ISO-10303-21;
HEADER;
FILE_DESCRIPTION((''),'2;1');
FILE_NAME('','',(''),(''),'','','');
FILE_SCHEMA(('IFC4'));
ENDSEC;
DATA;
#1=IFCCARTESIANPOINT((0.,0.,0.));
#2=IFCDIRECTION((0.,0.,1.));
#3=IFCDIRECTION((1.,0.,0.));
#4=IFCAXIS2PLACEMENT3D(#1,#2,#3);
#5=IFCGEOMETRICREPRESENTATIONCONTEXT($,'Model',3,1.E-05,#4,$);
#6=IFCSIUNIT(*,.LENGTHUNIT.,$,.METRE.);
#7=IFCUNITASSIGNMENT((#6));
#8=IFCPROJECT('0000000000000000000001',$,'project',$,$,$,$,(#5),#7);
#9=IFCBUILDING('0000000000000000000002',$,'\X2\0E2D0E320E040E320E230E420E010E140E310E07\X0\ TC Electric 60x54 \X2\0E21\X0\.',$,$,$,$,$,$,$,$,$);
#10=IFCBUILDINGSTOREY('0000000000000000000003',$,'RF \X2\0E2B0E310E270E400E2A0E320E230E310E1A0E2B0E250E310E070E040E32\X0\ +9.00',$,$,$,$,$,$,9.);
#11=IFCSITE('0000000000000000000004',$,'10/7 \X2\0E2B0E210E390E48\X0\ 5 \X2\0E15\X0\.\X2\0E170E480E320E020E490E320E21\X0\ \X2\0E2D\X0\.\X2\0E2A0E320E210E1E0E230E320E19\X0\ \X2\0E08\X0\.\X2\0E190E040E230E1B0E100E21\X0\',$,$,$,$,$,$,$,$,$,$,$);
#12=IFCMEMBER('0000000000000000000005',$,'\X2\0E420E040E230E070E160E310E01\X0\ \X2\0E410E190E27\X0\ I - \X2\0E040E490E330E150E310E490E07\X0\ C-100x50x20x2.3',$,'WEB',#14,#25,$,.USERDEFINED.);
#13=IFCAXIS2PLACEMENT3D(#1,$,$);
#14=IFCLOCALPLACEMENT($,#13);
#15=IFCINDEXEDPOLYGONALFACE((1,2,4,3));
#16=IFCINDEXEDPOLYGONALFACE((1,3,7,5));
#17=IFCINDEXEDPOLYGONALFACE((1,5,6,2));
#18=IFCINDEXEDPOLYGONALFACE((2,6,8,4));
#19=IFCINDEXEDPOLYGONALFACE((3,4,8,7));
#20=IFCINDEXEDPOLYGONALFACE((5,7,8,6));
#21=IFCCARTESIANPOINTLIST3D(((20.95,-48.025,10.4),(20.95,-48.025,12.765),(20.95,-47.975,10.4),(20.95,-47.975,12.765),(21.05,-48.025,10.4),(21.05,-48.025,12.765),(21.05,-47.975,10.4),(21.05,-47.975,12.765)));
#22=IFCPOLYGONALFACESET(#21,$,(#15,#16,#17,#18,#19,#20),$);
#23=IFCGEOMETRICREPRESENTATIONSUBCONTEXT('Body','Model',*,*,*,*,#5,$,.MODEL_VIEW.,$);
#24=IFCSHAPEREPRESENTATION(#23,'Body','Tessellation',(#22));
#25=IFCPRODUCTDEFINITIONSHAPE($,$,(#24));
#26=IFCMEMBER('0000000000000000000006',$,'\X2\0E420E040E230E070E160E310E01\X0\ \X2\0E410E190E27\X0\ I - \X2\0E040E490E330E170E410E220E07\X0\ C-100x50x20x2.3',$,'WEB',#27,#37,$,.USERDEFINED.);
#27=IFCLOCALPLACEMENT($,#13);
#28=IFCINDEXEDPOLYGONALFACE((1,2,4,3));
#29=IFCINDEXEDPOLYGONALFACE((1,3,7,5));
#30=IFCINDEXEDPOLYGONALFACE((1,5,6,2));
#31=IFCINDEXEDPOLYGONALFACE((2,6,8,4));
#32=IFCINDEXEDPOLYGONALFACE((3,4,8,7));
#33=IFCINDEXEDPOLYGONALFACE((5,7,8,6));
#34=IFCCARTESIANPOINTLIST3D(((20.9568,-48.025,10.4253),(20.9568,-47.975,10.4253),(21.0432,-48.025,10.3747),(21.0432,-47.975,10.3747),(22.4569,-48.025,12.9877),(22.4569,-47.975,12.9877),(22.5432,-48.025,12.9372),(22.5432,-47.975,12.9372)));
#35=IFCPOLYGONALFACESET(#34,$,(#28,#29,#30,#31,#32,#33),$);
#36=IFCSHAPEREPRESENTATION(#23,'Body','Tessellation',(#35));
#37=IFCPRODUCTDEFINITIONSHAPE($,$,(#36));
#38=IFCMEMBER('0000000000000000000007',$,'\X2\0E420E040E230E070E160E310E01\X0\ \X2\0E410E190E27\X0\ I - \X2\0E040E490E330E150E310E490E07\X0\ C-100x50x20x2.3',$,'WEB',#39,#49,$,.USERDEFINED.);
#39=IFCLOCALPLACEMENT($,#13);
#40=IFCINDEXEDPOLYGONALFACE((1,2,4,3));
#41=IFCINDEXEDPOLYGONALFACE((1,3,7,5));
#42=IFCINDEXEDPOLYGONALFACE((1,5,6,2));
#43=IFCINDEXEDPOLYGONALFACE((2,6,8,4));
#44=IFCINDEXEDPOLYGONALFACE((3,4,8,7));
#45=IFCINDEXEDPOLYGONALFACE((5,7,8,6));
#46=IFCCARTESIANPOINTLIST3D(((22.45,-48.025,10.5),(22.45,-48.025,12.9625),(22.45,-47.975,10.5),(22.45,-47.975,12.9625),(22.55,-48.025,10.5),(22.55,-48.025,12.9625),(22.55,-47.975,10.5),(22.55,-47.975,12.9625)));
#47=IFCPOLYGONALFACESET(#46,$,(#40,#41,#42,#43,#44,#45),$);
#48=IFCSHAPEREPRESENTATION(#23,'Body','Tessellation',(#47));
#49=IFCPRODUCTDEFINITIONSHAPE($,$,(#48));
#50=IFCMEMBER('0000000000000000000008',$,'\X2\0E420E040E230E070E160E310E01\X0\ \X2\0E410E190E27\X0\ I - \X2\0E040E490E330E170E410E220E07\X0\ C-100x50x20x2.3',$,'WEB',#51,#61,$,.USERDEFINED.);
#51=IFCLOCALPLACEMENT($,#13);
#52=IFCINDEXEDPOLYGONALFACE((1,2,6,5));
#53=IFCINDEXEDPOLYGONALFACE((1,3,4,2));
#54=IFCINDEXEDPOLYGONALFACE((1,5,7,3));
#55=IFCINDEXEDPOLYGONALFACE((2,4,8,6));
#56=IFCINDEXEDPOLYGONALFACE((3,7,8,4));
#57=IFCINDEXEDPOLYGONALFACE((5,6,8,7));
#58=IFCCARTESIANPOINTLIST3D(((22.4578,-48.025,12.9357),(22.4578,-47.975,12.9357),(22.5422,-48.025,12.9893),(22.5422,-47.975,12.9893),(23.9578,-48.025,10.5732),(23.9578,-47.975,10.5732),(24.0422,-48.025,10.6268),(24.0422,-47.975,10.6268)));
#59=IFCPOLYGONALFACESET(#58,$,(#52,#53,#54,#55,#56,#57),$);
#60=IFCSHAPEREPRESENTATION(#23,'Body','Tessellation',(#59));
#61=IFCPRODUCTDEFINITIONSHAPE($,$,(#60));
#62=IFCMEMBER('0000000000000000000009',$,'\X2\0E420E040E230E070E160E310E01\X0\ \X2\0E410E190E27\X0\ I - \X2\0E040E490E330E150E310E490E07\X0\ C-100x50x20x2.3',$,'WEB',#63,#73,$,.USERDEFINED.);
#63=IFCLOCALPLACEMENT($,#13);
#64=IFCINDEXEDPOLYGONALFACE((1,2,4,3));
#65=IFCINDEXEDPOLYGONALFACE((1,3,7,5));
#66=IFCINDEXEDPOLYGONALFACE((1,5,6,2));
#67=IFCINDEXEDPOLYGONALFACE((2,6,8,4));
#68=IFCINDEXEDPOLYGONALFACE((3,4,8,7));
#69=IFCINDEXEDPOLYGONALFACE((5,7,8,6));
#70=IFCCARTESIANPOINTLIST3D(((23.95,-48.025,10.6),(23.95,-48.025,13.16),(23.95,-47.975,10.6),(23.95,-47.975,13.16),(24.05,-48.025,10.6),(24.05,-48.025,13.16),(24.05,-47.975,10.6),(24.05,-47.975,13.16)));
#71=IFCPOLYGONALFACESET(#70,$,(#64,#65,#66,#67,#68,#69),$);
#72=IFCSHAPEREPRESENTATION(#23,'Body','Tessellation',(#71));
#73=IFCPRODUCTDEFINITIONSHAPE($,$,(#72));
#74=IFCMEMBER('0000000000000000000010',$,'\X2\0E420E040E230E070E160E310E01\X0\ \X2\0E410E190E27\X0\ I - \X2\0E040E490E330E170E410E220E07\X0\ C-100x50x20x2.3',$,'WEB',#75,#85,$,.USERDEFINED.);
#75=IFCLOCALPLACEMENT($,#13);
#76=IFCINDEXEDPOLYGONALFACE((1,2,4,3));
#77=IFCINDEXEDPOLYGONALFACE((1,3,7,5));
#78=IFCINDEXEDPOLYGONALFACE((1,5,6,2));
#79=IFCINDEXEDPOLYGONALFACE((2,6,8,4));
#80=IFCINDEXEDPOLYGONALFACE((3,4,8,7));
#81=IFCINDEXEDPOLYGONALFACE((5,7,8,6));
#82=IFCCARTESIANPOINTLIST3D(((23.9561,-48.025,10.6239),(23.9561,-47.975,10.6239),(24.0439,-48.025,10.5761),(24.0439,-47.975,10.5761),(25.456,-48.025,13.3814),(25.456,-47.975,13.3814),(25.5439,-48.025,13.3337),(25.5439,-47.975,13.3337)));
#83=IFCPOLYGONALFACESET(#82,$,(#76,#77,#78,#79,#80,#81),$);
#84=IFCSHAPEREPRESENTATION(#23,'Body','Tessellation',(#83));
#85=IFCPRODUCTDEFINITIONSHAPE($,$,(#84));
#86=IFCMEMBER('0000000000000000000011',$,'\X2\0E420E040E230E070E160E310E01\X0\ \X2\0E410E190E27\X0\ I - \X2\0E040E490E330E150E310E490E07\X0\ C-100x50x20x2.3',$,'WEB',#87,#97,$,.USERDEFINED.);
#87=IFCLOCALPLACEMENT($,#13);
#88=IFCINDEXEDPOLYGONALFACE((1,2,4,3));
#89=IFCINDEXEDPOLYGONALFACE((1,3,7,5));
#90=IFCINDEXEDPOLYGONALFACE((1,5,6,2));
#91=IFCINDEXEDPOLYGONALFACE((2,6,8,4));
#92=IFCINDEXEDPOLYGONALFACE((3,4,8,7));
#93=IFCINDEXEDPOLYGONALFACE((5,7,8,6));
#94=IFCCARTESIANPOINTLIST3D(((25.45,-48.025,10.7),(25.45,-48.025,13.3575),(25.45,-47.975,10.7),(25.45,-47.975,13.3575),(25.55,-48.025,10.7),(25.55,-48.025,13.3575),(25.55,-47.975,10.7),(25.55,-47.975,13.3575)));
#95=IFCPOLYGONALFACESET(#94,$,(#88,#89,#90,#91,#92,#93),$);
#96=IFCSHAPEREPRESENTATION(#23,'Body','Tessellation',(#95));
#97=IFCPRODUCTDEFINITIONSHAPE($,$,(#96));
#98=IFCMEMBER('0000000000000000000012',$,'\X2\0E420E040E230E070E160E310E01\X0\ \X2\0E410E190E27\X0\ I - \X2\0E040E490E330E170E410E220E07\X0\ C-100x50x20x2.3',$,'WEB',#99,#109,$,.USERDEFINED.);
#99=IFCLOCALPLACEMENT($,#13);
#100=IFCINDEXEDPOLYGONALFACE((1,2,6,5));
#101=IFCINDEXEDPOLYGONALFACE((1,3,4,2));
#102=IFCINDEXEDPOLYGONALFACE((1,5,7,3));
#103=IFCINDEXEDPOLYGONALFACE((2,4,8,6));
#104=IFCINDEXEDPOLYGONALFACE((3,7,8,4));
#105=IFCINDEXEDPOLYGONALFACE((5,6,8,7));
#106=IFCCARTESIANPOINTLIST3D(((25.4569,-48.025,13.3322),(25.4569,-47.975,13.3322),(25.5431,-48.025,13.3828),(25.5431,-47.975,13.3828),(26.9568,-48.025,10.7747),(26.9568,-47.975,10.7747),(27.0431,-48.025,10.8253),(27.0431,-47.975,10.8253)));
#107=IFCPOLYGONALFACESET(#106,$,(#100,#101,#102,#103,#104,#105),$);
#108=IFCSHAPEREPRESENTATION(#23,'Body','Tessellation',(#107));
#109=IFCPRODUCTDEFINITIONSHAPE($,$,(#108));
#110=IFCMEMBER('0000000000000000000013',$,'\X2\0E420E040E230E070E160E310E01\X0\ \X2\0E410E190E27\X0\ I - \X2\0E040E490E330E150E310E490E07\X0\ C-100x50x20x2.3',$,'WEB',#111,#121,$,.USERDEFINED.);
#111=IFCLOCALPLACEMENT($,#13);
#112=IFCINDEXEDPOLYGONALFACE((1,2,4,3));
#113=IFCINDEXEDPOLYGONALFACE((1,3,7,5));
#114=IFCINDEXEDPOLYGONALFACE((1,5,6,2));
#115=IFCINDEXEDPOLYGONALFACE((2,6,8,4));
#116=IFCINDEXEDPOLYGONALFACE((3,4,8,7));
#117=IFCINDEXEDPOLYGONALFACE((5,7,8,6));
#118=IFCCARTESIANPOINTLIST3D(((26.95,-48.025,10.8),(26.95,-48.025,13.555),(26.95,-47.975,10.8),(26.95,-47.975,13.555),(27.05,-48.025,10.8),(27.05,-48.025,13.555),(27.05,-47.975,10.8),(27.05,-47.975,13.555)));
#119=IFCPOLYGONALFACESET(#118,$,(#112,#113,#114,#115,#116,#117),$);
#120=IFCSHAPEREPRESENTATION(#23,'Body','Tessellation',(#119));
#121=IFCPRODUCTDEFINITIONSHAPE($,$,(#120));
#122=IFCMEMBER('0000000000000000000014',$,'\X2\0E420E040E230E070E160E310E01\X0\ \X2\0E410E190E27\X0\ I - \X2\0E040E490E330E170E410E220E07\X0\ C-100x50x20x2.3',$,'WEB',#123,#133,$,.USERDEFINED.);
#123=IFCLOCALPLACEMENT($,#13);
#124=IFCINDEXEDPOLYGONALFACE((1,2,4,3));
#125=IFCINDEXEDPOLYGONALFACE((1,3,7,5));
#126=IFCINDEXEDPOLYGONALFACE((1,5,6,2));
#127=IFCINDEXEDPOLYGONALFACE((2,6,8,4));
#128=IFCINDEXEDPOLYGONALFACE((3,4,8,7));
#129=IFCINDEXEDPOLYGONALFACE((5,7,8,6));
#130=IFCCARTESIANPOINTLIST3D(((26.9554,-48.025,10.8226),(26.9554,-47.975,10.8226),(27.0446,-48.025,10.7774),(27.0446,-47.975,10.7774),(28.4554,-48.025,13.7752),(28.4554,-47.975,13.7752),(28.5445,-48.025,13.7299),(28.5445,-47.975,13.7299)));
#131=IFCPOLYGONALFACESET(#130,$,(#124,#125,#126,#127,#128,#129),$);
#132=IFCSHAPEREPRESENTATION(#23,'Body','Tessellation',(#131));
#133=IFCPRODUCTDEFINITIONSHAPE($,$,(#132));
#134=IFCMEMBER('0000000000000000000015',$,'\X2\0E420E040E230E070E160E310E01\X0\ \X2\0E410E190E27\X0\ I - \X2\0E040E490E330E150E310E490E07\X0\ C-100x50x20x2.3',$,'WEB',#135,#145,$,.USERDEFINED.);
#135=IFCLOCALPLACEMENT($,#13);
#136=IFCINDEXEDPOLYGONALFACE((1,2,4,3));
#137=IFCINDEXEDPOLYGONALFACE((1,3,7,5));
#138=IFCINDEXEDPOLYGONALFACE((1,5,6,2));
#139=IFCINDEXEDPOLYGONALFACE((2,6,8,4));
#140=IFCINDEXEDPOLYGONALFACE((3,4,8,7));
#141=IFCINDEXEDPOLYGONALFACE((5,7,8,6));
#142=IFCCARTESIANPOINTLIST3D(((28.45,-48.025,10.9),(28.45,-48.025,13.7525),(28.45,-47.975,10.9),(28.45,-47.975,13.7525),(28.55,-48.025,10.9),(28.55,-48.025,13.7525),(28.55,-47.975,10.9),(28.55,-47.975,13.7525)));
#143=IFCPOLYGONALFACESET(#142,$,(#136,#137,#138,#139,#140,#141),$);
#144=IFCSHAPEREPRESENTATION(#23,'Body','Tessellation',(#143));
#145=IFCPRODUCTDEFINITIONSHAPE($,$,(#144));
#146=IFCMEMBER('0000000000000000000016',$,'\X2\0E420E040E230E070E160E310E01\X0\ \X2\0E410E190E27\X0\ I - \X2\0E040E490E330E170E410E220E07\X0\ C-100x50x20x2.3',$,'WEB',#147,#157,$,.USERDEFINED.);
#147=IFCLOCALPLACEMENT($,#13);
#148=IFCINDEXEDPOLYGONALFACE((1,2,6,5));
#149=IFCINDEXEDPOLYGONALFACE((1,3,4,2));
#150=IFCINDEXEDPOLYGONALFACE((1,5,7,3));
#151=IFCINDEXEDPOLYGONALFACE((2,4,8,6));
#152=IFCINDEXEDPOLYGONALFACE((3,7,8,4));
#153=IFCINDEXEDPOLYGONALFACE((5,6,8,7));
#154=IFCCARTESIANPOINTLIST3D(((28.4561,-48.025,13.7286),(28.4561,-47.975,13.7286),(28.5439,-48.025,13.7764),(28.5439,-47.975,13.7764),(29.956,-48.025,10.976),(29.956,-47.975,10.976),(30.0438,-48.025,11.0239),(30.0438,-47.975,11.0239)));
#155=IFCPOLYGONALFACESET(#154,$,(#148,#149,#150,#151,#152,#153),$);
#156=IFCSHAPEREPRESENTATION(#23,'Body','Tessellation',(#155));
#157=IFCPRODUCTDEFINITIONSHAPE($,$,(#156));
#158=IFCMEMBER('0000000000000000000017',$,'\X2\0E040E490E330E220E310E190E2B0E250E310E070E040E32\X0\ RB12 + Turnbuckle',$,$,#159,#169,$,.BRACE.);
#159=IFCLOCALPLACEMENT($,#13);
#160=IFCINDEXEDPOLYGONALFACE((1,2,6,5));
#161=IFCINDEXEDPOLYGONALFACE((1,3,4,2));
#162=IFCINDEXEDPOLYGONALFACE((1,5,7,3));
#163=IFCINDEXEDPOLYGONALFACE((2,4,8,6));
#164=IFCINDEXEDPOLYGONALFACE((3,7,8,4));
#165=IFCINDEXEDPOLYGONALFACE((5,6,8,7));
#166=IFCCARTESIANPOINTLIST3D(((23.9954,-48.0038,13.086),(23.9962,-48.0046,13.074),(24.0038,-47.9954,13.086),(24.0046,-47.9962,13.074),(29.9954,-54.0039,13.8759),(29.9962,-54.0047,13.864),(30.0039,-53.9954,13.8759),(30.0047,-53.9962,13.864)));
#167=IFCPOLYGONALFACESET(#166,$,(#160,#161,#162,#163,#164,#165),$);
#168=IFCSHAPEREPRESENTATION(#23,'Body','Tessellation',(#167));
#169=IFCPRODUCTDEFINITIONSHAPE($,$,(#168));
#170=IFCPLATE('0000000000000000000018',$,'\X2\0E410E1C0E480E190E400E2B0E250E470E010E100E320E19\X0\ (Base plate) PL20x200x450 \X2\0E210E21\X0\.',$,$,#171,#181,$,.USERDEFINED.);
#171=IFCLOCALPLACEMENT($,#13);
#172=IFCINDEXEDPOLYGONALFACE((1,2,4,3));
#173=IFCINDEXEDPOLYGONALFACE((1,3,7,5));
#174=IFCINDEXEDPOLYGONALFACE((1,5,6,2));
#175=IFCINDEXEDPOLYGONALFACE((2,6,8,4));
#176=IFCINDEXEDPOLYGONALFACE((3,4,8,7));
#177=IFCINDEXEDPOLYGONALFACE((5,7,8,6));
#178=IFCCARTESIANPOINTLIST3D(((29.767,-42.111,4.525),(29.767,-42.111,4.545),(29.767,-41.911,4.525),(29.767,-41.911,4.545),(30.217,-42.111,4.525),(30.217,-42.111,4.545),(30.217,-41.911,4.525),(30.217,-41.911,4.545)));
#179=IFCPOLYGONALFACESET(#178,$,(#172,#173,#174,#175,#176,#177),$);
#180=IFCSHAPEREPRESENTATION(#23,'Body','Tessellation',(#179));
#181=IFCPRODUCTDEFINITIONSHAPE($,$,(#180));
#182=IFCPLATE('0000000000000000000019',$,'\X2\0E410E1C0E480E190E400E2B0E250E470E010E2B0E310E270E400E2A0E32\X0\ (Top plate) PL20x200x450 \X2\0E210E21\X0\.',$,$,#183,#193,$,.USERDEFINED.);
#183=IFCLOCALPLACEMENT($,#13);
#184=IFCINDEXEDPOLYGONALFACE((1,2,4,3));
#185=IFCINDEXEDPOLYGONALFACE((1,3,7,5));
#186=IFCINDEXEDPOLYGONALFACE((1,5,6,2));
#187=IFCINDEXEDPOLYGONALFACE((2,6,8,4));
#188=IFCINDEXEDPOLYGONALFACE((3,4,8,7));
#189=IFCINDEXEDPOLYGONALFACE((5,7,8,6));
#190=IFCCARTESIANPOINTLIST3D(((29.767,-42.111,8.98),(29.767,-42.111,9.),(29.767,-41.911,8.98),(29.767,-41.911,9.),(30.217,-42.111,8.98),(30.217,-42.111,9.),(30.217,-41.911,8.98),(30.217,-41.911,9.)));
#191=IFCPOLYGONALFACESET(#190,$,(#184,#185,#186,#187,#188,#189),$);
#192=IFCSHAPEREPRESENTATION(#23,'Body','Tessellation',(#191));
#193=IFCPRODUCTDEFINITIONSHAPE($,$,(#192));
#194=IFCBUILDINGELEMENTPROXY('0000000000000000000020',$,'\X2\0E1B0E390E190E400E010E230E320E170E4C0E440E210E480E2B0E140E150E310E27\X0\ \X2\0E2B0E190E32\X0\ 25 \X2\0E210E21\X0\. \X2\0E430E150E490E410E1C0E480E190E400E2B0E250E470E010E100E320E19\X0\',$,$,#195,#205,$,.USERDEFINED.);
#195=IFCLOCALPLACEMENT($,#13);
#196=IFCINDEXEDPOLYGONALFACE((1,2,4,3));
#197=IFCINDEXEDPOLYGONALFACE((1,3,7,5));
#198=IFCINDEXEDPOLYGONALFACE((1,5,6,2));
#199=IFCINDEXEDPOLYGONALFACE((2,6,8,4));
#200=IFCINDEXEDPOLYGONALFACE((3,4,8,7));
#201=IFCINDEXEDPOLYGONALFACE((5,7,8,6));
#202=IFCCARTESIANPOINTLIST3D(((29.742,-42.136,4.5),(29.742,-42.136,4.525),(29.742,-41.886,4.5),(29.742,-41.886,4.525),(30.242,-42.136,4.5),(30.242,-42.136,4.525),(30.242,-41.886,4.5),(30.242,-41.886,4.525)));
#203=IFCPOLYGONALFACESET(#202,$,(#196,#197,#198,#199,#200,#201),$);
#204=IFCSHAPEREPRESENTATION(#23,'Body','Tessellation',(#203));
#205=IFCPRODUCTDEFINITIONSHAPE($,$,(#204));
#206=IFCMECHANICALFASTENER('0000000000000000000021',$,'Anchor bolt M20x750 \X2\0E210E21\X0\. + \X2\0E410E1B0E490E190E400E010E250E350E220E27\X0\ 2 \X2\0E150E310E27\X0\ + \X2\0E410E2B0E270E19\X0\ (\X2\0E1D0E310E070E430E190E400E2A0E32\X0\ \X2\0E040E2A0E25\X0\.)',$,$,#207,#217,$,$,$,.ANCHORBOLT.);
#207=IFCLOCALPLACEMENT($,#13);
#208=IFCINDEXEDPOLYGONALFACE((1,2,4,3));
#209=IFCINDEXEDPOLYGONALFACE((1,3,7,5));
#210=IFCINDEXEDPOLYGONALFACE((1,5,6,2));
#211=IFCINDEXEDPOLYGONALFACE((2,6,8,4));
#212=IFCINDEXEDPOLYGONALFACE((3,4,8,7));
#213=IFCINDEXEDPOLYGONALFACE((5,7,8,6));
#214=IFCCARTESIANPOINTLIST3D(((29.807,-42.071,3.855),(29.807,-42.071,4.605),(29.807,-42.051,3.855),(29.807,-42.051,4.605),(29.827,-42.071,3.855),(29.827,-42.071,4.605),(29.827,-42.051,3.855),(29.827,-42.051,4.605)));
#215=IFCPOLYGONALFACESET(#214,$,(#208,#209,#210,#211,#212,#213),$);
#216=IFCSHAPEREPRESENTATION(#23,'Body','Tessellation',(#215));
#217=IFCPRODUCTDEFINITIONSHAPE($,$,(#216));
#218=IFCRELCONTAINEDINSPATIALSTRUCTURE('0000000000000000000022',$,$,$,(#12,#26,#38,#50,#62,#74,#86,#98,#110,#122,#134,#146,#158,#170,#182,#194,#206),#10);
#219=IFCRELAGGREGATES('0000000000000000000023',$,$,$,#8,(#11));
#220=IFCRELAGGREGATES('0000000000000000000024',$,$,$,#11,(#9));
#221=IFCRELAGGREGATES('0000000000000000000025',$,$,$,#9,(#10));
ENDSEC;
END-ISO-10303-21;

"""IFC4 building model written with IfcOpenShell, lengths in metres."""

from ifc_helpers import new_model, si_unit, frame, origin, origin_with_axes, origin_2d, place, context, subcontext, project, spatial, rectangle, extrude, element, save


model = new_model("IFC4")

# Units and contexts
model_context = context("Model", 3, precision=1e-05, world=origin_with_axes())
body_context = subcontext(model_context, "Body", "Model", "MODEL_VIEW")
ifc_project = project(units=[si_unit("LENGTHUNIT", "METRE")], contexts=[model_context])

# Site, building, storey
site = spatial("IfcSite", under=ifc_project, Name="10/7 หมู่ 5 ต.ท่าข้าม อ.สามพราน จ.นครปฐม")
building = spatial("IfcBuilding", under=site, Name="อาคารโกดัง TC Electric 60x54 ม.")
storey = spatial("IfcBuildingStorey", under=building, Name="RF หัวเสารับหลังคา +9.00", Elevation=9.0)

# Members
member_1_placement = place(None, frame((21.0, -48.0, 10.4), z_axis=(0.0, 0.0, 1.0), x_axis=(0.0, 1.0, 0.0)))
element("IfcMember", 1, at=member_1_placement, inside=storey, Name="โครงถัก แนว I - ค้ำตั้ง C-100x50x20x2.3", ObjectType="WEB", PredefinedType="USERDEFINED", context=body_context, shape_type="SweptSolid", body=[
    extrude(rectangle(XDim=0.05, YDim=0.1, at=origin_2d()), origin(), (0.0, 0.0, 1.0), 2.365),
])
member_2_placement = place(None, frame((21.0, -48.0, 10.4), z_axis=(0.5052, 0.0, 0.863), x_axis=(0.0, -1.0, 0.0)))
element("IfcMember", 2, at=member_2_placement, inside=storey, Name="โครงถัก แนว I - ค้ำทแยง C-100x50x20x2.3", ObjectType="WEB", PredefinedType="USERDEFINED", context=body_context, shape_type="SweptSolid", body=[
    extrude(rectangle(XDim=0.05, YDim=0.1, at=origin_2d()), origin(), (0.0, 0.0, 1.0), 2.9692),
])
member_3_placement = place(None, frame((22.5, -48.0, 10.5), z_axis=(0.0, 0.0, 1.0), x_axis=(0.0, 1.0, 0.0)))
element("IfcMember", 3, at=member_3_placement, inside=storey, Name="โครงถัก แนว I - ค้ำตั้ง C-100x50x20x2.3", ObjectType="WEB", PredefinedType="USERDEFINED", context=body_context, shape_type="SweptSolid", body=[
    extrude(rectangle(XDim=0.05, YDim=0.1, at=origin_2d()), origin(), (0.0, 0.0, 1.0), 2.4625),
])
member_4_placement = place(None, frame((22.5, -48.0, 12.9625), z_axis=(0.536, 0.0, -0.8442), x_axis=(0.0, -1.0, 0.0)))
element("IfcMember", 4, at=member_4_placement, inside=storey, Name="โครงถัก แนว I - ค้ำทแยง C-100x50x20x2.3", ObjectType="WEB", PredefinedType="USERDEFINED", context=body_context, shape_type="SweptSolid", body=[
    extrude(rectangle(XDim=0.05, YDim=0.1, at=origin_2d()), origin(), (0.0, 0.0, 1.0), 2.7985),
])
member_5_placement = place(None, frame((24.0, -48.0, 10.6), z_axis=(0.0, 0.0, 1.0), x_axis=(0.0, 1.0, 0.0)))
element("IfcMember", 5, at=member_5_placement, inside=storey, Name="โครงถัก แนว I - ค้ำตั้ง C-100x50x20x2.3", ObjectType="WEB", PredefinedType="USERDEFINED", context=body_context, shape_type="SweptSolid", body=[
    extrude(rectangle(XDim=0.05, YDim=0.1, at=origin_2d()), origin(), (0.0, 0.0, 1.0), 2.56),
])
member_6_placement = place(None, frame((24.0, -48.0, 10.6), z_axis=(0.4778, 0.0, 0.8784), x_axis=(0.0, -1.0, 0.0)))
element("IfcMember", 6, at=member_6_placement, inside=storey, Name="โครงถัก แนว I - ค้ำทแยง C-100x50x20x2.3", ObjectType="WEB", PredefinedType="USERDEFINED", context=body_context, shape_type="SweptSolid", body=[
    extrude(rectangle(XDim=0.05, YDim=0.1, at=origin_2d()), origin(), (0.0, 0.0, 1.0), 3.1391),
])
member_7_placement = place(None, frame((25.5, -48.0, 10.7), z_axis=(0.0, 0.0, 1.0), x_axis=(0.0, 1.0, 0.0)))
element("IfcMember", 7, at=member_7_placement, inside=storey, Name="โครงถัก แนว I - ค้ำตั้ง C-100x50x20x2.3", ObjectType="WEB", PredefinedType="USERDEFINED", context=body_context, shape_type="SweptSolid", body=[
    extrude(rectangle(XDim=0.05, YDim=0.1, at=origin_2d()), origin(), (0.0, 0.0, 1.0), 2.6575),
])
member_8_placement = place(None, frame((25.5, -48.0, 13.3575), z_axis=(0.5059, 0.0, -0.8626), x_axis=(0.0, -1.0, 0.0)))
element("IfcMember", 8, at=member_8_placement, inside=storey, Name="โครงถัก แนว I - ค้ำทแยง C-100x50x20x2.3", ObjectType="WEB", PredefinedType="USERDEFINED", context=body_context, shape_type="SweptSolid", body=[
    extrude(rectangle(XDim=0.05, YDim=0.1, at=origin_2d()), origin(), (0.0, 0.0, 1.0), 2.9649),
])
member_9_placement = place(None, frame((27.0, -48.0, 10.8), z_axis=(0.0, 0.0, 1.0), x_axis=(0.0, 1.0, 0.0)))
element("IfcMember", 9, at=member_9_placement, inside=storey, Name="โครงถัก แนว I - ค้ำตั้ง C-100x50x20x2.3", ObjectType="WEB", PredefinedType="USERDEFINED", context=body_context, shape_type="SweptSolid", body=[
    extrude(rectangle(XDim=0.05, YDim=0.1, at=origin_2d()), origin(), (0.0, 0.0, 1.0), 2.755),
])
member_10_placement = place(None, frame((27.0, -48.0, 10.8), z_axis=(0.4529, 0.0, 0.8915), x_axis=(0.0, -1.0, 0.0)))
element("IfcMember", 10, at=member_10_placement, inside=storey, Name="โครงถัก แนว I - ค้ำทแยง C-100x50x20x2.3", ObjectType="WEB", PredefinedType="USERDEFINED", context=body_context, shape_type="SweptSolid", body=[
    extrude(rectangle(XDim=0.05, YDim=0.1, at=origin_2d()), origin(), (0.0, 0.0, 1.0), 3.3117),
])
member_11_placement = place(None, frame((28.5, -48.0, 10.9), z_axis=(0.0, 0.0, 1.0), x_axis=(0.0, 1.0, 0.0)))
element("IfcMember", 11, at=member_11_placement, inside=storey, Name="โครงถัก แนว I - ค้ำตั้ง C-100x50x20x2.3", ObjectType="WEB", PredefinedType="USERDEFINED", context=body_context, shape_type="SweptSolid", body=[
    extrude(rectangle(XDim=0.05, YDim=0.1, at=origin_2d()), origin(), (0.0, 0.0, 1.0), 2.8525),
])
member_12_placement = place(None, frame((28.5, -48.0, 13.7525), z_axis=(0.4785, 0.0, -0.8781), x_axis=(0.0, -1.0, 0.0)))
element("IfcMember", 12, at=member_12_placement, inside=storey, Name="โครงถัก แนว I - ค้ำทแยง C-100x50x20x2.3", ObjectType="WEB", PredefinedType="USERDEFINED", context=body_context, shape_type="SweptSolid", body=[
    extrude(rectangle(XDim=0.05, YDim=0.1, at=origin_2d()), origin(), (0.0, 0.0, 1.0), 3.1347),
])
member_13_placement = place(None, frame((24.0, -48.0, 13.08), z_axis=(0.7041, -0.7041, 0.0927), x_axis=(-0.7071, -0.7071, 0.0)))
element("IfcMember", 13, at=member_13_placement, inside=storey, Name="ค้ำยันหลังคา RB12 + Turnbuckle", PredefinedType="BRACE", context=body_context, shape_type="SweptSolid", body=[
    extrude(rectangle(XDim=0.012, YDim=0.012, at=origin_2d()), origin(), (0.0, 0.0, 1.0), 8.522),
])

# Plates
for number, where, z_axis, x_axis, name in (
    (14, (29.992, -42.011, 4.525), (0.0, 0.0, 1.0), (1.0, 0.0, 0.0), "แผ่นเหล็กฐาน (Base plate) PL20x200x450 มม."),
    (15, (29.992, -42.011, 8.98), (0.0, 0.0, 1.0), (1.0, 0.0, 0.0), "แผ่นเหล็กหัวเสา (Top plate) PL20x200x450 มม."),
):
    element("IfcPlate", number, at=place(None, frame(where, z_axis=z_axis, x_axis=x_axis)), inside=storey, Name=name, PredefinedType="USERDEFINED", context=body_context, shape_type="SweptSolid", body=[
        extrude(rectangle(XDim=0.45, YDim=0.2, at=origin_2d()), origin(), (0.0, 0.0, 1.0), 0.02),
    ])

# Building element proxy
proxy_placement = place(None, frame((29.992, -42.011, 4.5), z_axis=(0.0, 0.0, 1.0), x_axis=(1.0, 0.0, 0.0)))
element("IfcBuildingElementProxy", 16, at=proxy_placement, inside=storey, Name="ปูนเกราท์ไม่หดตัว หนา 25 มม. ใต้แผ่นเหล็กฐาน", PredefinedType="USERDEFINED", context=body_context, shape_type="SweptSolid", body=[
    extrude(rectangle(XDim=0.5, YDim=0.25, at=origin_2d()), origin(), (0.0, 0.0, 1.0), 0.025),
])

# Mechanical fastener
for number, where, z_axis, x_axis, name in (
    (17, (29.817, -42.061, 3.855), (0.0, 0.0, 1.0), (1.0, 0.0, 0.0), "Anchor bolt M20x750 มม. + แป้นเกลียว 2 ตัว + แหวน (ฝังในเสา คสล.)"),
):
    element("IfcMechanicalFastener", number, at=place(None, frame(where, z_axis=z_axis, x_axis=x_axis)), inside=storey, Name=name, PredefinedType="ANCHORBOLT", context=body_context, shape_type="SweptSolid", body=[
        extrude(rectangle(XDim=0.02, YDim=0.02, at=origin_2d()), origin(), (0.0, 0.0, 1.0), 0.75),
    ])

save(model, "model.ifc")
